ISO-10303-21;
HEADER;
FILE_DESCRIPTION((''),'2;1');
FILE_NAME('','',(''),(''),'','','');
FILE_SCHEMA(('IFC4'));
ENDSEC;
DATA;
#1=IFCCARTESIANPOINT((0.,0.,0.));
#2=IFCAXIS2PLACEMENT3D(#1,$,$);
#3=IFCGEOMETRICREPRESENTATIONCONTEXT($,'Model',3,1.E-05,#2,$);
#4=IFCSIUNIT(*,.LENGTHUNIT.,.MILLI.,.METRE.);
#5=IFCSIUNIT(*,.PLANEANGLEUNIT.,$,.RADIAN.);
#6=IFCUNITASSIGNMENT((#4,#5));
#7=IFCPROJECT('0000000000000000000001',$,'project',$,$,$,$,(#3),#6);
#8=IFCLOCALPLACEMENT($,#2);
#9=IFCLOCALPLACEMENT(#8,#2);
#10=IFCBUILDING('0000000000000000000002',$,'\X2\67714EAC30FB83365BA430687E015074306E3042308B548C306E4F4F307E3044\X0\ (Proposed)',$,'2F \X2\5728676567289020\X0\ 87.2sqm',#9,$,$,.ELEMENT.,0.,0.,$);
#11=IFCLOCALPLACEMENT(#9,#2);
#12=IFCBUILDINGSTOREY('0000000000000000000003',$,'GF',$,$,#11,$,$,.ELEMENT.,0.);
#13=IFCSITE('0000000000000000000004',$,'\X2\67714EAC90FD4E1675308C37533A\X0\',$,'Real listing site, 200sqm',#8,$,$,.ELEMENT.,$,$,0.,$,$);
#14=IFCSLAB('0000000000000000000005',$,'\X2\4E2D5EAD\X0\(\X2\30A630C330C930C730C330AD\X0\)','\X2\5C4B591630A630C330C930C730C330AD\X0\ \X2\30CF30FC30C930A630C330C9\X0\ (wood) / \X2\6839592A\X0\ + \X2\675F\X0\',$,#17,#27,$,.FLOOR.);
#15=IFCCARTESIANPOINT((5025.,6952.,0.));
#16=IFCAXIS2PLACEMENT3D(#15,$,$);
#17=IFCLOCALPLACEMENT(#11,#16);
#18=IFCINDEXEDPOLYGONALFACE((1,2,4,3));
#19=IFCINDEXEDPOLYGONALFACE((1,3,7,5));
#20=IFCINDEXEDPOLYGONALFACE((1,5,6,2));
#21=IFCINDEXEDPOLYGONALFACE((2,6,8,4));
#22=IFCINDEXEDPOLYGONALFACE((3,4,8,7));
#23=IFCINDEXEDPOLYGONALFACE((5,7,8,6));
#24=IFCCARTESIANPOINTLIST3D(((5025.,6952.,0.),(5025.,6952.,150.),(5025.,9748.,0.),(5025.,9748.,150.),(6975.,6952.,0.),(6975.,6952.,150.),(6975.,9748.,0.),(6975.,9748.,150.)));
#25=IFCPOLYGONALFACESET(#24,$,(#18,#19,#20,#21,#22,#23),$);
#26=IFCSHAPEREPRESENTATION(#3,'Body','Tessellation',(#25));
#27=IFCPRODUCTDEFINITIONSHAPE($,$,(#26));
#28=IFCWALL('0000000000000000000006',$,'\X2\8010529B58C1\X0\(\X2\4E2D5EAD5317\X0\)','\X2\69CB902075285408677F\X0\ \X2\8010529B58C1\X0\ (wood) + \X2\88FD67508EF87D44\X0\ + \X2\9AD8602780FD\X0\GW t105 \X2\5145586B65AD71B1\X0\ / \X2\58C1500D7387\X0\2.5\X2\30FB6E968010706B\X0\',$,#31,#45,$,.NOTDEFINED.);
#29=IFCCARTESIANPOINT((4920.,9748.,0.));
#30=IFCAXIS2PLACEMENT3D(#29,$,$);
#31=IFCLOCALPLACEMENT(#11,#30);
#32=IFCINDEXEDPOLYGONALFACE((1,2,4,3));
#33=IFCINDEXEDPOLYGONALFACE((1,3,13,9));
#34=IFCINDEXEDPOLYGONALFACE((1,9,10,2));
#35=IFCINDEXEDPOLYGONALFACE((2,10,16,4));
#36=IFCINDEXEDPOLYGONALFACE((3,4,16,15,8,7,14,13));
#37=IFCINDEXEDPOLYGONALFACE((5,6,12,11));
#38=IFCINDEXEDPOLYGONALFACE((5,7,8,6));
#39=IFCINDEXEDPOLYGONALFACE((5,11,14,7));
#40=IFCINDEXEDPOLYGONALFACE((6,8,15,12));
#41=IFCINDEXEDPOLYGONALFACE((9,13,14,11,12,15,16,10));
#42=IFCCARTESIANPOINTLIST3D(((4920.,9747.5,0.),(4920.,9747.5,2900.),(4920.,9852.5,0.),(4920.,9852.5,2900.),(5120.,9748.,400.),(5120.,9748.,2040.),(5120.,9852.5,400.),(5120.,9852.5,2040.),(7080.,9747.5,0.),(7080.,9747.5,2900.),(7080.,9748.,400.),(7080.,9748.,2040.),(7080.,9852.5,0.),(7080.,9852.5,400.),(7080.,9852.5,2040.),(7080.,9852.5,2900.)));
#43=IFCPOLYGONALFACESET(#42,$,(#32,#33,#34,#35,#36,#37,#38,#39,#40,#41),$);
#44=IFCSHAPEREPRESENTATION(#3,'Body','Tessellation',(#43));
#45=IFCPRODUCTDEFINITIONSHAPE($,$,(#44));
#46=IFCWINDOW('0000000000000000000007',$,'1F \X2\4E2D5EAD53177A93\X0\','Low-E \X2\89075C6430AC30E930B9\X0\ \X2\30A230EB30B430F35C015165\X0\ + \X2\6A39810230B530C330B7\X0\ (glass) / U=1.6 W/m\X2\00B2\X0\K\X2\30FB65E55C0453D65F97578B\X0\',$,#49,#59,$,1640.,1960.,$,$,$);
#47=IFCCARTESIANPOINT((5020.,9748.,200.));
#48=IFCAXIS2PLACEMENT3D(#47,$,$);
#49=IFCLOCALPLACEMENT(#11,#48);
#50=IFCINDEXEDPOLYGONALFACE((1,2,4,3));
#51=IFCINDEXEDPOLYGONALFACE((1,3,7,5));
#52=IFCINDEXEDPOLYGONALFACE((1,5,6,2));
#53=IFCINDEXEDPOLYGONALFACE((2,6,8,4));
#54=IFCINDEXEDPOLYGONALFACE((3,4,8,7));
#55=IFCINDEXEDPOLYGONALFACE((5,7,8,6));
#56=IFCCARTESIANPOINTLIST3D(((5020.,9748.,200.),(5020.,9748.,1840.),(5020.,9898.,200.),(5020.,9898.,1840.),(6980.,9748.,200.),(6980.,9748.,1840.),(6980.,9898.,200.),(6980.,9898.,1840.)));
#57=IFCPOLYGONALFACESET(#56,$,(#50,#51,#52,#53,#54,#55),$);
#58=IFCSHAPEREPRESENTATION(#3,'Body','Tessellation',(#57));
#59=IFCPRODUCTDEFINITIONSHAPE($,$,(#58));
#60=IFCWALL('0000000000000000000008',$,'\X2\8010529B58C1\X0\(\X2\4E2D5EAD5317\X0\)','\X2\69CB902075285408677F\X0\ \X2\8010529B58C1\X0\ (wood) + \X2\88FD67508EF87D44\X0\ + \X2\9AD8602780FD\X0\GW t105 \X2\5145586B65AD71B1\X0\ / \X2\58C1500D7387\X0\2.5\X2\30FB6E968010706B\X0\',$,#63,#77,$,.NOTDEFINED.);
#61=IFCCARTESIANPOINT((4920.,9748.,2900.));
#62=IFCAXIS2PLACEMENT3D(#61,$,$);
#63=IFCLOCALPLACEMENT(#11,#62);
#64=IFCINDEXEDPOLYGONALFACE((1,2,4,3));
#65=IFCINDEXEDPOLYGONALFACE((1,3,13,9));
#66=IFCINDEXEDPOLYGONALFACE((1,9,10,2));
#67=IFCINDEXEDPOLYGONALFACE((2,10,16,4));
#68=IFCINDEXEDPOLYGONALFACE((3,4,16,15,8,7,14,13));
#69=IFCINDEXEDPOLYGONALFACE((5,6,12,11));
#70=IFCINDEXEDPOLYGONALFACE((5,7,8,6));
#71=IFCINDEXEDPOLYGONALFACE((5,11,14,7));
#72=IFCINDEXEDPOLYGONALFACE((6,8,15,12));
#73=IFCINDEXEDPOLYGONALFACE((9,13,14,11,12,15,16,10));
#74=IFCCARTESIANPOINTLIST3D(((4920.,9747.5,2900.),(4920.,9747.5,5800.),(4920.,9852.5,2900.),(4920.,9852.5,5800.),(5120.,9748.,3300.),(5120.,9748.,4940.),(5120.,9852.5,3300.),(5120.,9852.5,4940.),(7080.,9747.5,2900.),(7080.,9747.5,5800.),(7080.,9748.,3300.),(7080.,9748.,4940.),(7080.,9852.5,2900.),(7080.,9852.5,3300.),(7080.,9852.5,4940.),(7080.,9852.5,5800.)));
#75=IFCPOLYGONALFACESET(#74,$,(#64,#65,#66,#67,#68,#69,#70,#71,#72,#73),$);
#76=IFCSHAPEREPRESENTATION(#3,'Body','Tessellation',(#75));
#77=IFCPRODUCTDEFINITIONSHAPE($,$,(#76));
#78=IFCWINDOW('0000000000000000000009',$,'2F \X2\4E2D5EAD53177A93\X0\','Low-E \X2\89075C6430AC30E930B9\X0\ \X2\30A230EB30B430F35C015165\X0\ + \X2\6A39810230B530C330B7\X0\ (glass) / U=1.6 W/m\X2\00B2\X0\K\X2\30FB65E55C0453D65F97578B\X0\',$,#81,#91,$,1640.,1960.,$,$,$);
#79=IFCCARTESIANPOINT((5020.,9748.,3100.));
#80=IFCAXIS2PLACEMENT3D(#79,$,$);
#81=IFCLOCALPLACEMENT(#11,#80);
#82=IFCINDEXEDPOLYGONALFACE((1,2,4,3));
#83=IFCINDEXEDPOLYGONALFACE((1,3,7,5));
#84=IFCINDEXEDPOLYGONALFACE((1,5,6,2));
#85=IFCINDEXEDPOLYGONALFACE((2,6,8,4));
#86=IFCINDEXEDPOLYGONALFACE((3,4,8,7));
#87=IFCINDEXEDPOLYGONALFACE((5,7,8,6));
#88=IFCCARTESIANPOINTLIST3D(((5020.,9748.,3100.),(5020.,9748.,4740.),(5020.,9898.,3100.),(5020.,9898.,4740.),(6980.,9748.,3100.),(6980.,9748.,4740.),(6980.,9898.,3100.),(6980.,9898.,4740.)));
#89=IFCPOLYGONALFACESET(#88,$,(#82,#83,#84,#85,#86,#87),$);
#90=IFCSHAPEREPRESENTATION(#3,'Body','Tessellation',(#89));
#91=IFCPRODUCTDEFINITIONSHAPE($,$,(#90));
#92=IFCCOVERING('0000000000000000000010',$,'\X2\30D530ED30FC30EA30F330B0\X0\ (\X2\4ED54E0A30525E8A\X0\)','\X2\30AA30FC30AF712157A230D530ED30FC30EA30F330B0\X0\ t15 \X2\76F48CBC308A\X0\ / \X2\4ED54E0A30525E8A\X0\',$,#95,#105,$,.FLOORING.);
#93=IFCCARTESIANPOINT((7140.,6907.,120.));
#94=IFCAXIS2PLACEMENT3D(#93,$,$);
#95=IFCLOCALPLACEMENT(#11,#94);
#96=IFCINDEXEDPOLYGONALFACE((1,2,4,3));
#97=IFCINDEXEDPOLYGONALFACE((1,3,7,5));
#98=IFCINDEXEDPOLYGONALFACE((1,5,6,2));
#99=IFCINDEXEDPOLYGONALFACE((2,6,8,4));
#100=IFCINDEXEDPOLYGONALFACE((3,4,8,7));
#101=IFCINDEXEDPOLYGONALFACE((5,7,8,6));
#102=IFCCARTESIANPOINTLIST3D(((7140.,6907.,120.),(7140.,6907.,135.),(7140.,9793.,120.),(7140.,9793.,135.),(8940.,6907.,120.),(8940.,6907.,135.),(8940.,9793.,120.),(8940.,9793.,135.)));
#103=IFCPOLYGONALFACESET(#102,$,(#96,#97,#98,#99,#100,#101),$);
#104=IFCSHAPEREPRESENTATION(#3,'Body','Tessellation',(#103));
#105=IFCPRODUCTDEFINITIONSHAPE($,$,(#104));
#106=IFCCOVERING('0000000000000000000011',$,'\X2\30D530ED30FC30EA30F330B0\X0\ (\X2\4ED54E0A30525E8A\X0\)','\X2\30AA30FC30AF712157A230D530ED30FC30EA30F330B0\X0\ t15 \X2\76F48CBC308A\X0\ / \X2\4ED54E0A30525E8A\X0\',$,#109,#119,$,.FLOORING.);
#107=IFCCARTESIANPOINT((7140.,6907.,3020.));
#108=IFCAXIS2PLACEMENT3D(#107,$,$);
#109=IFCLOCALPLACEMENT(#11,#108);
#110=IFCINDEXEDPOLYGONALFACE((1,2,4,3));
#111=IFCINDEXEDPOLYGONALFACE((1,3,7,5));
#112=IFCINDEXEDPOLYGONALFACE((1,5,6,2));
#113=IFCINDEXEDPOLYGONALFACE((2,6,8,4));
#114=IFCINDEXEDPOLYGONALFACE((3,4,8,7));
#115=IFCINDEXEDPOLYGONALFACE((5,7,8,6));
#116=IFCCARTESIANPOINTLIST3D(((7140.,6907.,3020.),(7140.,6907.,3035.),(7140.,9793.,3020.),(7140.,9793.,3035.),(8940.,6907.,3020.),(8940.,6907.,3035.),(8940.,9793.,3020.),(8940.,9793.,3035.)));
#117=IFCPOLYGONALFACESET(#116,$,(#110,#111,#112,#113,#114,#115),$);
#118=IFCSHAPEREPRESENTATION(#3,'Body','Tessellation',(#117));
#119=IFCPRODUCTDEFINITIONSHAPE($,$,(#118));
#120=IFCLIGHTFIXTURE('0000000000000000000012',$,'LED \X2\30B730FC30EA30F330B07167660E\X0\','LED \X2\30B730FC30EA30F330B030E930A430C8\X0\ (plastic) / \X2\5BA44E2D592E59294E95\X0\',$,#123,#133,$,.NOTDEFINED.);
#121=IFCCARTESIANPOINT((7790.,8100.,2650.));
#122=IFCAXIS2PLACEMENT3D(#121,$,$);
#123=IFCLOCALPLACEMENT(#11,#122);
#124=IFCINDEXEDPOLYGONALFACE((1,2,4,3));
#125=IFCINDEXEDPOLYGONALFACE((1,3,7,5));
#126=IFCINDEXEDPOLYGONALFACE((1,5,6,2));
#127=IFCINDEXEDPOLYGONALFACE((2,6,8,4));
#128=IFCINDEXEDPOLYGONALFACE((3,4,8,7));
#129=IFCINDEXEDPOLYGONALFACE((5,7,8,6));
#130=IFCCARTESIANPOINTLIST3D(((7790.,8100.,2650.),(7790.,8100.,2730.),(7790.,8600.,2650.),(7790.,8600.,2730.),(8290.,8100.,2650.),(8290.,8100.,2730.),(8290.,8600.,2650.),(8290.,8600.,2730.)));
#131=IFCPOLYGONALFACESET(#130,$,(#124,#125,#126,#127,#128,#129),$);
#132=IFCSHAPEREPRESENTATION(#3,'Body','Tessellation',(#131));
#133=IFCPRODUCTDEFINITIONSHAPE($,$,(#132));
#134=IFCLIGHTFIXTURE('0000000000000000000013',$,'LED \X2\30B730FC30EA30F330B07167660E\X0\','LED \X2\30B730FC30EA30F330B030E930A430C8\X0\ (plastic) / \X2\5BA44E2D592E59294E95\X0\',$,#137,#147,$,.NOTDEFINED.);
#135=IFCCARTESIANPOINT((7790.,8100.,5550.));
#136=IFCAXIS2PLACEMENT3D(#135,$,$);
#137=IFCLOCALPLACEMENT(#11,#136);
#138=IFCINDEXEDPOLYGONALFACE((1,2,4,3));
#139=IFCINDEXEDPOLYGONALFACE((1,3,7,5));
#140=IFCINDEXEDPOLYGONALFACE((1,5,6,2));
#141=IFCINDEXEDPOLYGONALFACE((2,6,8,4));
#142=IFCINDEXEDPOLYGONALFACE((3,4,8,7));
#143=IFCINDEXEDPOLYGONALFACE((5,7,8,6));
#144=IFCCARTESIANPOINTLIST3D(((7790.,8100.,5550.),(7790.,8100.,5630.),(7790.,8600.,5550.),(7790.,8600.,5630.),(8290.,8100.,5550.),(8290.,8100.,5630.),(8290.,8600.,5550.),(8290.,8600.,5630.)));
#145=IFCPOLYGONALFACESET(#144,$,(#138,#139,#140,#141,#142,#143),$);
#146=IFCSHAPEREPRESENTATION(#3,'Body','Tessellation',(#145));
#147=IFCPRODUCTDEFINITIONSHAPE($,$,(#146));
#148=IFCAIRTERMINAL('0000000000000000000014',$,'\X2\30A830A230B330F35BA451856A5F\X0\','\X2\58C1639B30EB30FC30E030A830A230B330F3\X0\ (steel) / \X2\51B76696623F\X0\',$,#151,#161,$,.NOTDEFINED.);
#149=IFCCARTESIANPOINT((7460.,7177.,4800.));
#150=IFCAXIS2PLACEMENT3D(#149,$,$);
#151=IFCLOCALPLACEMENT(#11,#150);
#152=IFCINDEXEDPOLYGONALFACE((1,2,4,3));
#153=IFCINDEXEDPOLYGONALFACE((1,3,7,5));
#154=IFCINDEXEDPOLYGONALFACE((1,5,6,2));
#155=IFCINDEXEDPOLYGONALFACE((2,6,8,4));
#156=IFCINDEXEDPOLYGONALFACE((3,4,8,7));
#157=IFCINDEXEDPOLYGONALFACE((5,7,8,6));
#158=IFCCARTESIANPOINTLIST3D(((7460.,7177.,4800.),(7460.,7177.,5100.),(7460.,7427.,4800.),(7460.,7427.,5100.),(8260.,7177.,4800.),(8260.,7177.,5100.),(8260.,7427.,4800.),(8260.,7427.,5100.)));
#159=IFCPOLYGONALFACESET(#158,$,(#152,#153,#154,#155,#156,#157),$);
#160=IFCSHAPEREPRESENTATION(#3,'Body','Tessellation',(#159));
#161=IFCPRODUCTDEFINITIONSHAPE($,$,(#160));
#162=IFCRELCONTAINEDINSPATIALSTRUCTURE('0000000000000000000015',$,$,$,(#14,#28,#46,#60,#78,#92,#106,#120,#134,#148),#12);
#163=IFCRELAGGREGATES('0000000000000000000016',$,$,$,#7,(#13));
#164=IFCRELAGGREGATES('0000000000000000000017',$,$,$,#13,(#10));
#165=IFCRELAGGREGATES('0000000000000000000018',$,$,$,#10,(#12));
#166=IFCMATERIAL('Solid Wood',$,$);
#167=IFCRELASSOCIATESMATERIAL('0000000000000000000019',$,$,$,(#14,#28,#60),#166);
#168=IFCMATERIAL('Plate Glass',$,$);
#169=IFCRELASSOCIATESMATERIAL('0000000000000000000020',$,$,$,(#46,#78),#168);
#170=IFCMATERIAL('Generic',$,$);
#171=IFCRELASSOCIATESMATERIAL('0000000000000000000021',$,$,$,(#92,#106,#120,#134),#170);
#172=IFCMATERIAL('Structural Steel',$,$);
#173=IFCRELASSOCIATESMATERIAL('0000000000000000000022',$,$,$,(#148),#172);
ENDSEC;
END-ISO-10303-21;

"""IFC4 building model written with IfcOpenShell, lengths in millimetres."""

from ifc_helpers import new_model, si_unit, frame, frame_2d, origin, place, context, project, spatial, rectangle, extrude, material, element, fill, save


model = new_model("IFC4")

# Units and contexts
model_context = context("Model", 3, precision=1e-05, world=origin())
ifc_project = project(units=[si_unit("LENGTHUNIT", "METRE", prefix="MILLI"), si_unit("PLANEANGLEUNIT", "RADIAN")], contexts=[model_context])

# Site, building, storey
site_placement = place(None, origin())
site = spatial("IfcSite", under=ifc_project, at=site_placement, Name="東京都世田谷区", ObjectType="Real listing site, 200sqm", CompositionType="ELEMENT", RefElevation=0.0)
building_placement = place(site_placement, origin())
building = spatial("IfcBuilding", under=site, at=building_placement, Name="東京・茶室と縁側のある和の住まい (Proposed)", ObjectType="2F 在来木造 87.2sqm", CompositionType="ELEMENT", ElevationOfRefHeight=0.0, ElevationOfTerrain=0.0)
storey_placement = place(building_placement, origin())
storey = spatial("IfcBuildingStorey", under=building, at=storey_placement, Name="GF", CompositionType="ELEMENT", Elevation=0.0)

# Shared definitions
ifc_material_1 = material(Name="Solid Wood")

# Slab
slab_placement = place(storey_placement, frame((5025.0, 6952.0, 0.0)))
element("IfcSlab", 1, at=slab_placement, inside=storey, material=ifc_material_1, Name="中庭(ウッドデッキ)", Description="屋外ウッドデッキ ハードウッド (wood) / 根太 + 束", PredefinedType="FLOOR", context=model_context, shape_type="SweptSolid", body=[
    extrude(rectangle(XDim=1950.0, YDim=2796.0, at=frame_2d((975.0, 1398.0))), frame((5025.0, 6952.0, 0.0)), (0.0, 0.0, 1.0), 150.0),
])

# Walls, openings, windows
wall_1_placement = place(storey_placement, frame((4920.0, 9748.0, 0.0)))
wall_1 = element("IfcWall", 2, at=wall_1_placement, inside=storey, material=ifc_material_1, Name="耐力壁(中庭北)", Description="構造用合板 耐力壁 (wood) + 製材軸組 + 高性能GW t105 充填断熱 / 壁倍率2.5・準耐火", PredefinedType="NOTDEFINED", context=model_context, shape_type="SweptSolid", body=[
    extrude(rectangle(XDim=2160.0, YDim=105.0, at=frame_2d((1080.0, 52.0))), frame((4920.0, 9748.0, 0.0)), (0.0, 0.0, 1.0), 2900.0),
])
opening_1_placement = place(storey_placement, frame((5020.0, 9748.0, 200.0)))
opening_1 = element("IfcOpeningElement", 3, at=opening_1_placement, cuts=wall_1, PredefinedType="NOTDEFINED", context=model_context, shape_type="SweptSolid", body=[
    extrude(rectangle(XDim=1960.0, YDim=150.0, at=frame_2d((980.0, 75.0))), frame((5020.0, 9748.0, 200.0)), (0.0, 0.0, 1.0), 1640.0),
])
ifc_material_2 = material(Name="Plate Glass")
window_1_placement = place(storey_placement, frame((5020.0, 9748.0, 200.0)))
window_1 = element("IfcWindow", 4, at=window_1_placement, inside=storey, material=ifc_material_2, Name="1F 中庭北窓", Description="Low-E 複層ガラス アルゴン封入 + 樹脂サッシ (glass) / U=1.6 W/m²K・日射取得型", OverallHeight=1640.0, OverallWidth=1960.0, context=model_context, shape_type="SweptSolid", body=[
    extrude(rectangle(XDim=1960.0, YDim=150.0, at=frame_2d((980.0, 75.0))), frame((5020.0, 9748.0, 200.0)), (0.0, 0.0, 1.0), 1640.0),
])
fill(opening_1, window_1)
wall_2_placement = place(storey_placement, frame((4920.0, 9748.0, 2900.0)))
wall_2 = element("IfcWall", 5, at=wall_2_placement, inside=storey, material=ifc_material_1, Name="耐力壁(中庭北)", Description="構造用合板 耐力壁 (wood) + 製材軸組 + 高性能GW t105 充填断熱 / 壁倍率2.5・準耐火", PredefinedType="NOTDEFINED", context=model_context, shape_type="SweptSolid", body=[
    extrude(rectangle(XDim=2160.0, YDim=105.0, at=frame_2d((1080.0, 52.0))), frame((4920.0, 9748.0, 2900.0)), (0.0, 0.0, 1.0), 2900.0),
])
opening_2_placement = place(storey_placement, frame((5020.0, 9748.0, 3100.0)))
opening_2 = element("IfcOpeningElement", 6, at=opening_2_placement, cuts=wall_2, PredefinedType="NOTDEFINED", context=model_context, shape_type="SweptSolid", body=[
    extrude(rectangle(XDim=1960.0, YDim=150.0, at=frame_2d((980.0, 75.0))), frame((5020.0, 9748.0, 3100.0)), (0.0, 0.0, 1.0), 1640.0),
])
window_2_placement = place(storey_placement, frame((5020.0, 9748.0, 3100.0)))
window_2 = element("IfcWindow", 7, at=window_2_placement, inside=storey, material=ifc_material_2, Name="2F 中庭北窓", Description="Low-E 複層ガラス アルゴン封入 + 樹脂サッシ (glass) / U=1.6 W/m²K・日射取得型", OverallHeight=1640.0, OverallWidth=1960.0, context=model_context, shape_type="SweptSolid", body=[
    extrude(rectangle(XDim=1960.0, YDim=150.0, at=frame_2d((980.0, 75.0))), frame((5020.0, 9748.0, 3100.0)), (0.0, 0.0, 1.0), 1640.0),
])
fill(opening_2, window_2)

# Coverings
ifc_material_3 = material(Name="Generic")
covering_1_placement = place(storey_placement, frame((7140.0, 6907.0, 120.0)))
element("IfcCovering", 8, at=covering_1_placement, inside=storey, material=ifc_material_3, Name="フローリング (仕上げ床)", Description="オーク無垢フローリング t15 直貼り / 仕上げ床", PredefinedType="FLOORING", context=model_context, shape_type="SweptSolid", body=[
    extrude(rectangle(XDim=1800.0, YDim=2886.0, at=frame_2d((900.0, 1443.0))), frame((7140.0, 6907.0, 120.0)), (0.0, 0.0, 1.0), 15.0),
])
covering_2_placement = place(storey_placement, frame((7140.0, 6907.0, 3020.0)))
element("IfcCovering", 9, at=covering_2_placement, inside=storey, material=ifc_material_3, Name="フローリング (仕上げ床)", Description="オーク無垢フローリング t15 直貼り / 仕上げ床", PredefinedType="FLOORING", context=model_context, shape_type="SweptSolid", body=[
    extrude(rectangle(XDim=1800.0, YDim=2886.0, at=frame_2d((900.0, 1443.0))), frame((7140.0, 6907.0, 3020.0)), (0.0, 0.0, 1.0), 15.0),
])

# Light fixtures
light_fixture_1_placement = place(storey_placement, frame((7790.0, 8100.0, 2650.0)))
element("IfcLightFixture", 10, at=light_fixture_1_placement, inside=storey, material=ifc_material_3, Name="LED シーリング照明", Description="LED シーリングライト (plastic) / 室中央天井", PredefinedType="NOTDEFINED", context=model_context, shape_type="SweptSolid", body=[
    extrude(rectangle(XDim=500.0, YDim=500.0, at=frame_2d((250.0, 250.0))), frame((7790.0, 8100.0, 2650.0)), (0.0, 0.0, 1.0), 80.0),
])
light_fixture_2_placement = place(storey_placement, frame((7790.0, 8100.0, 5550.0)))
element("IfcLightFixture", 11, at=light_fixture_2_placement, inside=storey, material=ifc_material_3, Name="LED シーリング照明", Description="LED シーリングライト (plastic) / 室中央天井", PredefinedType="NOTDEFINED", context=model_context, shape_type="SweptSolid", body=[
    extrude(rectangle(XDim=500.0, YDim=500.0, at=frame_2d((250.0, 250.0))), frame((7790.0, 8100.0, 5550.0)), (0.0, 0.0, 1.0), 80.0),
])

# Air terminal
ifc_material_4 = material(Name="Structural Steel")
air_terminal_placement = place(storey_placement, frame((7460.0, 7177.0, 4800.0)))
element("IfcAirTerminal", 12, at=air_terminal_placement, inside=storey, material=ifc_material_4, Name="エアコン室内機", Description="壁掛ルームエアコン (steel) / 冷暖房", PredefinedType="NOTDEFINED", context=model_context, shape_type="SweptSolid", body=[
    extrude(rectangle(XDim=800.0, YDim=250.0, at=frame_2d((400.0, 125.0))), frame((7460.0, 7177.0, 4800.0)), (0.0, 0.0, 1.0), 300.0),
])

save(model, "model.ifc")
